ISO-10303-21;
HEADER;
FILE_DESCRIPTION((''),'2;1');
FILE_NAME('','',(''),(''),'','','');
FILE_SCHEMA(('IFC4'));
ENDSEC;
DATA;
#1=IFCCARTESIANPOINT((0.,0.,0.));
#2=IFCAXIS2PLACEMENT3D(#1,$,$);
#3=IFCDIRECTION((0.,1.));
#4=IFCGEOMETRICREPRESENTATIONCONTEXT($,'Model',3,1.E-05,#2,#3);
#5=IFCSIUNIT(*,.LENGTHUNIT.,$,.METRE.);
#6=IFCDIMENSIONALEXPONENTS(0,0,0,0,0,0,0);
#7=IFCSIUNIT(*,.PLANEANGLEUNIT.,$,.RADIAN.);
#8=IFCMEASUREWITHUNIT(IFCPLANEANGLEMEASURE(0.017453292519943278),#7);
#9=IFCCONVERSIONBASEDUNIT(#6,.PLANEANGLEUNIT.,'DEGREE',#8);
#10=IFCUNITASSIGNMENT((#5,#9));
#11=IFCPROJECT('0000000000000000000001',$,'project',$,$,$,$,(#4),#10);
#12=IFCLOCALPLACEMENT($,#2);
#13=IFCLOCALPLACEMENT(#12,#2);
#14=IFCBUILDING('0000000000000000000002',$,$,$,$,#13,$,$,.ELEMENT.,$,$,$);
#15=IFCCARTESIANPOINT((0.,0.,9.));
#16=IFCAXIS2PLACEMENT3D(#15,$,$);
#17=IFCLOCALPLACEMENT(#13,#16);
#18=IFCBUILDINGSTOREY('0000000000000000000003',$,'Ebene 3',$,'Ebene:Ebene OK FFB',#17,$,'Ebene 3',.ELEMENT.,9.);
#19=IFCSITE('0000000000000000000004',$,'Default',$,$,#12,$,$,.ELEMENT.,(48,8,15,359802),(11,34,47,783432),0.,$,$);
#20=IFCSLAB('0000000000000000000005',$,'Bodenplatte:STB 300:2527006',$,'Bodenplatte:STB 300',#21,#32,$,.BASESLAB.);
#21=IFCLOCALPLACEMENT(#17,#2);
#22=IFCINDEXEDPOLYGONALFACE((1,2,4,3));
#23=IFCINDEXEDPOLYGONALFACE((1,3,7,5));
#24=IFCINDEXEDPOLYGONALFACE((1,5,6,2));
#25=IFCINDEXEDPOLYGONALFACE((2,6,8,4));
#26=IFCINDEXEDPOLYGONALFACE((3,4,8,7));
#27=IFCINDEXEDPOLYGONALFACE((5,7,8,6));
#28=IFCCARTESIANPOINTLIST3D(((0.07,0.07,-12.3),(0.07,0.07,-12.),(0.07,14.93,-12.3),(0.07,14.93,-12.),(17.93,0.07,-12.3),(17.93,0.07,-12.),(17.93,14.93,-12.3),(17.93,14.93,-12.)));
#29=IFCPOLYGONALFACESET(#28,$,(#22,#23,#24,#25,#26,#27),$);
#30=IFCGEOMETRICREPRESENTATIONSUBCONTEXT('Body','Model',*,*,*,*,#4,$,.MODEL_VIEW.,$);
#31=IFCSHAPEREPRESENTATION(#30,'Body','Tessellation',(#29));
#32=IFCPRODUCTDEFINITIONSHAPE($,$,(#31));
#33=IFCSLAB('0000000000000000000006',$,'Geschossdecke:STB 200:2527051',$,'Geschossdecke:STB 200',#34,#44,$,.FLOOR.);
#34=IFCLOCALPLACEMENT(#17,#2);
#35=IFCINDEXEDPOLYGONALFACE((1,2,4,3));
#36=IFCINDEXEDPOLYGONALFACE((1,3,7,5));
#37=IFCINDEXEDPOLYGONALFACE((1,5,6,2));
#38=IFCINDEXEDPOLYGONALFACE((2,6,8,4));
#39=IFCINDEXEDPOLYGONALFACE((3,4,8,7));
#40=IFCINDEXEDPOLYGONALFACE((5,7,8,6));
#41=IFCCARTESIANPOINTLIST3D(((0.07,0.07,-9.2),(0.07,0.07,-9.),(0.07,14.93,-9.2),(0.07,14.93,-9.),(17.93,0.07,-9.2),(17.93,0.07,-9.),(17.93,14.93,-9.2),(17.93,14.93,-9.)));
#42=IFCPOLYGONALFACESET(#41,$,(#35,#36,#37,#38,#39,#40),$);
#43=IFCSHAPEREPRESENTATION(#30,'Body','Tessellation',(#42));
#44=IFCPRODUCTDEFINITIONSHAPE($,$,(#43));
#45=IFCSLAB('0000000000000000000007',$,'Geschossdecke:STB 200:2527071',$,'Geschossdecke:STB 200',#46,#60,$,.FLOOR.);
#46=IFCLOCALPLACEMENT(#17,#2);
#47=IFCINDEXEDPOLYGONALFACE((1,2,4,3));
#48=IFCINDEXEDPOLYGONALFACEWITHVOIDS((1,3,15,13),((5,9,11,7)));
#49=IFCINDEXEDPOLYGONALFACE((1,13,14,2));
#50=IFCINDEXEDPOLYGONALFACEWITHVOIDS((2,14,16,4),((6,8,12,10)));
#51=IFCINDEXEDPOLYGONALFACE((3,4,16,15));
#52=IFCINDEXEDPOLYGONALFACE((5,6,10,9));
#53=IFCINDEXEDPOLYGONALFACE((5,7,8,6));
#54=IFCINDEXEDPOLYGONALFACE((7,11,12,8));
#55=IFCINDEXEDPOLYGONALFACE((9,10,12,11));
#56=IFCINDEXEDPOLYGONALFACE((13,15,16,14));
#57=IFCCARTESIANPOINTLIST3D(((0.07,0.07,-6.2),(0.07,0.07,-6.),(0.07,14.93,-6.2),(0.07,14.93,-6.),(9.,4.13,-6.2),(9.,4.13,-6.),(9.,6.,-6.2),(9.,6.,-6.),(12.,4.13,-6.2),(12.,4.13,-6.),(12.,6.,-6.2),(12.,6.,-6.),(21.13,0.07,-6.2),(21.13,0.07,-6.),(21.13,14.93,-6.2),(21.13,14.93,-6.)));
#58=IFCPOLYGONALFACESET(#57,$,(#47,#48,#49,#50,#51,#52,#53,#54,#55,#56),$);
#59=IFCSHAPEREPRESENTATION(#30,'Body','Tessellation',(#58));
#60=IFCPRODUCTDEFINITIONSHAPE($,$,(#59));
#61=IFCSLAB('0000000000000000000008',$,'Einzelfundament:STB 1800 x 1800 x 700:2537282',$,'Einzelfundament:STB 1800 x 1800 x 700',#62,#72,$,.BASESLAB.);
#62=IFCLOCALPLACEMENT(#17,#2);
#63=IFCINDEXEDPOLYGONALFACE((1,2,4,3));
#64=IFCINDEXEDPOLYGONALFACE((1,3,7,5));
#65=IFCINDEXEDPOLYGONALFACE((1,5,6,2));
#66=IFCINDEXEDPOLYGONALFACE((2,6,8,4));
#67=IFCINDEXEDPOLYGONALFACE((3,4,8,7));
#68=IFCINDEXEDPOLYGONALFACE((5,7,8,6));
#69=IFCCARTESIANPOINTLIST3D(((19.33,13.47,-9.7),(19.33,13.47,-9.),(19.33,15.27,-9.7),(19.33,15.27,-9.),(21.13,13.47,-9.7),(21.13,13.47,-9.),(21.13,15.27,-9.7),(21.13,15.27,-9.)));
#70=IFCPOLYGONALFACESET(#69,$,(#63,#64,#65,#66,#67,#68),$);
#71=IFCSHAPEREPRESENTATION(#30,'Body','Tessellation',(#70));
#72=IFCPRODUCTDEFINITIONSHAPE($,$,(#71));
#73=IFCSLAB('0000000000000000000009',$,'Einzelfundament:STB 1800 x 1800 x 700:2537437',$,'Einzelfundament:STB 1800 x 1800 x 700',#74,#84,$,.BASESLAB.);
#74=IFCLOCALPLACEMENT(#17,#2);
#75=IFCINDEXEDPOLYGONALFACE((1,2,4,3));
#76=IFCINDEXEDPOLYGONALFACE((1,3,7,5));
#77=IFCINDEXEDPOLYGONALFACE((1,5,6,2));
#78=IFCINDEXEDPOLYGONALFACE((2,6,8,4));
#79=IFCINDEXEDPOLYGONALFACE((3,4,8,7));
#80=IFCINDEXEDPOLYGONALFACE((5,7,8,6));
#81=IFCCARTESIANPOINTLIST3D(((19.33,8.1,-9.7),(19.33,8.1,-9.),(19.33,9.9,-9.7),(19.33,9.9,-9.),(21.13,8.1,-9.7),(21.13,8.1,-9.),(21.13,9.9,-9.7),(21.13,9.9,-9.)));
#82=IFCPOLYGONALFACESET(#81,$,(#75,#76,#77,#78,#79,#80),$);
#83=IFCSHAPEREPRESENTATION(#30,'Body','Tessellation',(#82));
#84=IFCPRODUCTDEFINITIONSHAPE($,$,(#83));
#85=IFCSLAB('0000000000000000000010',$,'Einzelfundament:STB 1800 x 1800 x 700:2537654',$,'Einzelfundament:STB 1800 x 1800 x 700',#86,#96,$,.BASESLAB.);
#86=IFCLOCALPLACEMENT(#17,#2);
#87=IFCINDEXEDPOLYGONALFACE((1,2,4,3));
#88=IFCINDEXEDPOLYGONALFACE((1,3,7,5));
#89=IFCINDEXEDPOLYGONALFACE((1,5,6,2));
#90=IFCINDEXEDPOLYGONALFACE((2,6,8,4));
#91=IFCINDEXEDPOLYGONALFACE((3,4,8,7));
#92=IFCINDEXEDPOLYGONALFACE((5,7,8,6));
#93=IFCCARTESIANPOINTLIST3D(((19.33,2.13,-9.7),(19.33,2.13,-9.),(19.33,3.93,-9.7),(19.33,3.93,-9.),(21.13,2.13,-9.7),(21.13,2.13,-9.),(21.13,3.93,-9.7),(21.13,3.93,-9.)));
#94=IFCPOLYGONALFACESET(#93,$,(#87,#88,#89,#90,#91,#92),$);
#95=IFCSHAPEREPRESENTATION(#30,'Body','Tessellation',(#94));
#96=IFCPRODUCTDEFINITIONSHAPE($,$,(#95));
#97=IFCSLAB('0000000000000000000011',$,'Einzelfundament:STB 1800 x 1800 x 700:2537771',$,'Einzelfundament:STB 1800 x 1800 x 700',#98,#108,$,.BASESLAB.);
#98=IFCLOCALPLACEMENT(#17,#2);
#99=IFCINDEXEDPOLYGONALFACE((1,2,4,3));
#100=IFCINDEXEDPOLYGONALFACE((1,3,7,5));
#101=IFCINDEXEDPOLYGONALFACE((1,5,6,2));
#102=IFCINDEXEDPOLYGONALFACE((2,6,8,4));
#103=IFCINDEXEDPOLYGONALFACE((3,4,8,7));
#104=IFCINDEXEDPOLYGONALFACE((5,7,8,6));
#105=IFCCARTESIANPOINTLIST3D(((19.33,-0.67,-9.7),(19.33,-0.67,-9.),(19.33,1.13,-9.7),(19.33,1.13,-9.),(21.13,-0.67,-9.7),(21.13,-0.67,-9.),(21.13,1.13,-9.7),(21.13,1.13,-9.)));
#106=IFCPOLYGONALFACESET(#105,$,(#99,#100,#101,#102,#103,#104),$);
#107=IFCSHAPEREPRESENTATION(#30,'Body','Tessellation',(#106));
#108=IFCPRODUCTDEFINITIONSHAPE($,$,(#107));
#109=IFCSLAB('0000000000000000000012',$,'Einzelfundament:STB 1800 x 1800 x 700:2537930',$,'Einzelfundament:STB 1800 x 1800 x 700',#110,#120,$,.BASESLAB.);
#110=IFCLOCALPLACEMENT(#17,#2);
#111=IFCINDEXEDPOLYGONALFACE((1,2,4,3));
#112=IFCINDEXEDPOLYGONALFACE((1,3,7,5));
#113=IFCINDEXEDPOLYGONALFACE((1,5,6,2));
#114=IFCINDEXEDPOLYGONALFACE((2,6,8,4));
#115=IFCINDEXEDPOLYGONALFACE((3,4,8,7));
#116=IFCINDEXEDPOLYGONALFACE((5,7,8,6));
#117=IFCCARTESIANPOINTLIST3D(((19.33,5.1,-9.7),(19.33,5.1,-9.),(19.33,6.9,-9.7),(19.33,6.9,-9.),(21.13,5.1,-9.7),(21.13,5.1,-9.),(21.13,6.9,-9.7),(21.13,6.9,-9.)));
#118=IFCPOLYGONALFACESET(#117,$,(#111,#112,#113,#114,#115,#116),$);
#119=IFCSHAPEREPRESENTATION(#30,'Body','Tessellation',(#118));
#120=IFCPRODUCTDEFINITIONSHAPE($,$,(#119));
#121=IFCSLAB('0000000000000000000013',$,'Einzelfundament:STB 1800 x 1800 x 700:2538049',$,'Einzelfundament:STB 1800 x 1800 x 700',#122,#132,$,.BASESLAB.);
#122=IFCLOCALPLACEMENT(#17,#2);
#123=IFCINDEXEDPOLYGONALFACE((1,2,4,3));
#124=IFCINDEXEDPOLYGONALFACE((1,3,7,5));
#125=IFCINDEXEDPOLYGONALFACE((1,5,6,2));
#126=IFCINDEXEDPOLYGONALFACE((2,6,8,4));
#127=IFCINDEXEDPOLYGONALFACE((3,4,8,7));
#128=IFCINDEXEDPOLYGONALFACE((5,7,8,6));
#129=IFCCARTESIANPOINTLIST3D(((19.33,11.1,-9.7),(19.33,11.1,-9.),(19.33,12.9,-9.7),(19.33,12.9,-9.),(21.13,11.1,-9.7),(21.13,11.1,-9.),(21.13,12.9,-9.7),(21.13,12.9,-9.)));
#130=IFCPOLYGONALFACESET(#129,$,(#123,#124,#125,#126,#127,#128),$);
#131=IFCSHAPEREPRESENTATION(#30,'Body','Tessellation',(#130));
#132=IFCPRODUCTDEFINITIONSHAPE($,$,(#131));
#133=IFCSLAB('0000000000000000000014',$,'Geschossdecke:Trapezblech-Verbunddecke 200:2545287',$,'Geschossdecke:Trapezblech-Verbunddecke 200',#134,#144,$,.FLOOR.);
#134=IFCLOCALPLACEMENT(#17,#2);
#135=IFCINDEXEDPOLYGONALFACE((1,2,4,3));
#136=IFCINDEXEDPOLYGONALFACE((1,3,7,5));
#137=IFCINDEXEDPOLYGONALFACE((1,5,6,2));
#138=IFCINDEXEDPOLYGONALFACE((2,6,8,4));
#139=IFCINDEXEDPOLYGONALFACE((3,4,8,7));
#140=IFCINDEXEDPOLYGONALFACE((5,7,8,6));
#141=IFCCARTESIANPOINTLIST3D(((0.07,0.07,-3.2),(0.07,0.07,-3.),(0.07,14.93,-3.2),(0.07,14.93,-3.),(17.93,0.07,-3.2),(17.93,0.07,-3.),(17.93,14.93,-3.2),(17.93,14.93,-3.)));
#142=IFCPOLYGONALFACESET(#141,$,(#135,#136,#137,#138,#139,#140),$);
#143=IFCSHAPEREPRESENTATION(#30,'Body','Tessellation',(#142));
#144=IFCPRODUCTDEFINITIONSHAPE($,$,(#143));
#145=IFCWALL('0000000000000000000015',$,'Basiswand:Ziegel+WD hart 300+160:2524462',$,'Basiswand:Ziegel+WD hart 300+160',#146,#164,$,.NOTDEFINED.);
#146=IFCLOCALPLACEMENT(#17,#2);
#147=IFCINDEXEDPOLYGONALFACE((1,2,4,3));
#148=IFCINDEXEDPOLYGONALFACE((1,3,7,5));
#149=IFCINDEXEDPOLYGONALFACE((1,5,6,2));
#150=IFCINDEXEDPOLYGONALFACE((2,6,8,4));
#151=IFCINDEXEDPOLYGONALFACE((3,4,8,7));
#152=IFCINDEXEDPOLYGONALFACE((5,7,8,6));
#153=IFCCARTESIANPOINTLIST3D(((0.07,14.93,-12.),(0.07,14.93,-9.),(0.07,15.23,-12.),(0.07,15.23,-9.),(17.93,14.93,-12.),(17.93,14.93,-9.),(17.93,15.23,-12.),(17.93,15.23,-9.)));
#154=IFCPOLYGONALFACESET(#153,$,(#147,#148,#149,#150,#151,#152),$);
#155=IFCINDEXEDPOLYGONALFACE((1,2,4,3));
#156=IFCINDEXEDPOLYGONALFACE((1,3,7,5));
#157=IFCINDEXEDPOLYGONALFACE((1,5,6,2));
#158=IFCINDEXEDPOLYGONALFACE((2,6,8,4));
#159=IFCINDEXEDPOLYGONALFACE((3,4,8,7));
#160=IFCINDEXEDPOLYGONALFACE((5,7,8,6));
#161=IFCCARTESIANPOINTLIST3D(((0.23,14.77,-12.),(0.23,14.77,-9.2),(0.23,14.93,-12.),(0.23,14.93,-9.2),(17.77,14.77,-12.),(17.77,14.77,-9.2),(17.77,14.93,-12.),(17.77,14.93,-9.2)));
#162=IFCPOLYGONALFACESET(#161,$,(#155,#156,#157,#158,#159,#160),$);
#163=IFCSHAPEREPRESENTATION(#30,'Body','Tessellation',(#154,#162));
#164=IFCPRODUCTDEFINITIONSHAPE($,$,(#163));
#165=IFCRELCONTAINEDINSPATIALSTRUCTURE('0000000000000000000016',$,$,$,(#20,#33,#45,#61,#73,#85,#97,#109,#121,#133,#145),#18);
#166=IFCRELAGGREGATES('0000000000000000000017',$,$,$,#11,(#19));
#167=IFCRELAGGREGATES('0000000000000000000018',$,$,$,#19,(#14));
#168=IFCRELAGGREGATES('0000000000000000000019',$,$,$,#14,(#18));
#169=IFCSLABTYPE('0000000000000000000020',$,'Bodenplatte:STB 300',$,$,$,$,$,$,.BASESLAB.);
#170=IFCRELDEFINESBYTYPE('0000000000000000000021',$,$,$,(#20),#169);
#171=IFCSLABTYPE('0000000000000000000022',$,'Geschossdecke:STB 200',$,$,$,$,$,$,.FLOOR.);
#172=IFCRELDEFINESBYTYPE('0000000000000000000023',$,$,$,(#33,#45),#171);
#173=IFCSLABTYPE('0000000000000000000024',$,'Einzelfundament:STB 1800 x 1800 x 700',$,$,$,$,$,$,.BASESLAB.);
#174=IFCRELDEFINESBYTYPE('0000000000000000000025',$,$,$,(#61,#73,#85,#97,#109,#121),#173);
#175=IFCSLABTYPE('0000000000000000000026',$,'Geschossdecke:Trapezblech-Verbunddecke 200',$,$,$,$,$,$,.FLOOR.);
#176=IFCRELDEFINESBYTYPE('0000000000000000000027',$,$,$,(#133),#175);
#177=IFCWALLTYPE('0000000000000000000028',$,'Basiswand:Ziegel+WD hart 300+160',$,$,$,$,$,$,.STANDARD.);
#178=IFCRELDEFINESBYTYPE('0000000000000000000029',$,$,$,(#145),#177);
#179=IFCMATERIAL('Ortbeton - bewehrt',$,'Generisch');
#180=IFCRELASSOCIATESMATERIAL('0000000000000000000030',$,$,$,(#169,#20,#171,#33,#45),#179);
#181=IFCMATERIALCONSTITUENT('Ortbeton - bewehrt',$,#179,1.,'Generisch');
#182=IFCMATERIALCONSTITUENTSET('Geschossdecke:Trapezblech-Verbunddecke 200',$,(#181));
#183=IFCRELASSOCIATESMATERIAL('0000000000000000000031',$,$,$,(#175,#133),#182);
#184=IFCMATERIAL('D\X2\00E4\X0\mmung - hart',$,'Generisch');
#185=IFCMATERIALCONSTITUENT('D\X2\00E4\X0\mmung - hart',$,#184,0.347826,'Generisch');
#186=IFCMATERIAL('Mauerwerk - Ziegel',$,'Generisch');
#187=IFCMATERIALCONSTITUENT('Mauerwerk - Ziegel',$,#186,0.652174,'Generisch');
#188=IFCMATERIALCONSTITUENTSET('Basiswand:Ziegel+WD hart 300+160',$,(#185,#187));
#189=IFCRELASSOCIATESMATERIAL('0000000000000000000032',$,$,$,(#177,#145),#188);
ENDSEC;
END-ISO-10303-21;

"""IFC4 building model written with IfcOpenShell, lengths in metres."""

from ifc_helpers import new_model, entity, si_unit, converted_unit, direction, frame, origin, place, context, subcontext, project, spatial, indexed_curve, outline, extrude, material, constituent, constituent_set, type_object, element, save


model = new_model("IFC4")

# Units and contexts
model_context = context("Model", 3, precision=1e-05, world=origin(), true_north=direction((0.0, 1.0)))
body_context = subcontext(model_context, "Body", "Model", "MODEL_VIEW")
ifc_project = project(units=[si_unit("LENGTHUNIT", "METRE"), converted_unit("PLANEANGLEUNIT", "DEGREE", entity("IfcPlaneAngleMeasure", 0.017453292519943278), si_unit("PLANEANGLEUNIT", "RADIAN"), dimensions=[0, 0, 0, 0, 0, 0, 0])], contexts=[model_context])

# Site, building, storey
site_placement = place(None, origin())
site = spatial("IfcSite", under=ifc_project, at=site_placement, Name="Default", CompositionType="ELEMENT", RefLatitude=(48, 8, 15, 359802), RefLongitude=(11, 34, 47, 783432), RefElevation=0.0)
building_placement = place(site_placement, origin())
building = spatial("IfcBuilding", under=site, at=building_placement, CompositionType="ELEMENT")
storey_placement = place(building_placement, frame((0.0, 0.0, 9.0)))
storey = spatial("IfcBuildingStorey", under=building, at=storey_placement, Name="Ebene 3", ObjectType="Ebene:Ebene OK FFB", LongName="Ebene 3", CompositionType="ELEMENT", Elevation=9.0)

# Slabs
ifc_material_1 = material(Name="Ortbeton - bewehrt", Category="Generisch")
slab_type_1 = type_object("IfcSlabType", Name="Bodenplatte:STB 300", PredefinedType="BASESLAB", material=ifc_material_1)
slab_1_placement = place(storey_placement, origin())
element("IfcSlab", 1, at=slab_1_placement, inside=storey, type_object=slab_type_1, material=ifc_material_1, Name="Bodenplatte:STB 300:2527006", ObjectType="Bodenplatte:STB 300", PredefinedType="BASESLAB", context=body_context, shape_type="SweptSolid", body=[
    extrude(outline(indexed_curve([(-7.43, -8.93), (7.43, -8.93), (7.43, 8.93), (-7.43, 8.93), (-7.43, -8.93)], self_intersect=False)), frame((9.0, 7.5, -12.0), z_axis=(0.0, 0.0, -1.0), x_axis=(0.0, 1.0, 0.0)), (0.0, 0.0, 1.0), 0.3),
])
slab_type_2 = type_object("IfcSlabType", Name="Geschossdecke:STB 200", PredefinedType="FLOOR", material=ifc_material_1)
slab_2_placement = place(storey_placement, origin())
element("IfcSlab", 2, at=slab_2_placement, inside=storey, type_object=slab_type_2, material=ifc_material_1, Name="Geschossdecke:STB 200:2527051", ObjectType="Geschossdecke:STB 200", PredefinedType="FLOOR", context=body_context, shape_type="SweptSolid", body=[
    extrude(outline(indexed_curve([(-7.43, -8.93), (7.43, -8.93), (7.43, 8.93), (-7.43, 8.93), (-7.43, -8.93)], self_intersect=False)), frame((9.0, 7.5, -9.0), z_axis=(0.0, 0.0, -1.0), x_axis=(0.0, 1.0, 0.0)), (0.0, 0.0, 1.0), 0.2),
])

# Slab, opening
slab_3_placement = place(storey_placement, origin())
slab_3 = element("IfcSlab", 3, at=slab_3_placement, inside=storey, type_object=slab_type_2, material=ifc_material_1, Name="Geschossdecke:STB 200:2527071", ObjectType="Geschossdecke:STB 200", PredefinedType="FLOOR", context=body_context, shape_type="SweptSolid", body=[
    extrude(outline(indexed_curve([(-10.53, -7.43), (10.53, -7.43), (10.53, 7.43), (-10.53, 7.43), (-10.53, -7.43)], self_intersect=False), holes=[indexed_curve([(1.4, -1.5), (1.4, -3.37), (-1.6, -3.37), (-1.6, -1.5), (1.4, -1.5)], self_intersect=False)]), frame((10.6, 7.5, -6.2)), (0.0, 0.0, 1.0), 0.2),
])
opening_1_placement = place(slab_3_placement, origin())
element("IfcOpeningElement", 4, at=opening_1_placement, cuts=slab_3, PredefinedType="OPENING", context=body_context, shape_type="SweptSolid", body=[
    extrude(outline(indexed_curve([(12.0, 6.0), (9.0, 6.0), (9.0, 4.13), (12.0, 4.13), (12.0, 6.0)], self_intersect=False)), frame((0.0, 0.0, -9.0)), (0.0, 0.0, -1.0), 14.86),
])

# Slabs
slab_type_3 = type_object("IfcSlabType", Name="Einzelfundament:STB 1800 x 1800 x 700", PredefinedType="BASESLAB")
slab_4_placement = place(storey_placement, origin())
element("IfcSlab", 5, at=slab_4_placement, inside=storey, type_object=slab_type_3, Name="Einzelfundament:STB 1800 x 1800 x 700:2537282", ObjectType="Einzelfundament:STB 1800 x 1800 x 700", PredefinedType="BASESLAB", context=body_context, shape_type="SweptSolid", body=[
    extrude(outline(indexed_curve([(-0.9, -0.9), (0.9, -0.9), (0.9, 0.9), (-0.9, 0.9), (-0.9, -0.9)], self_intersect=False)), frame((20.23, 14.37, -9.7), z_axis=(0.0, 0.0, 1.0), x_axis=(-1.0, 0.0, 0.0)), (0.0, 0.0, 1.0), 0.7),
])
slab_5_placement = place(storey_placement, origin())
element("IfcSlab", 6, at=slab_5_placement, inside=storey, type_object=slab_type_3, Name="Einzelfundament:STB 1800 x 1800 x 700:2537437", ObjectType="Einzelfundament:STB 1800 x 1800 x 700", PredefinedType="BASESLAB", context=body_context, shape_type="SweptSolid", body=[
    extrude(outline(indexed_curve([(-0.9, -0.9), (0.9, -0.9), (0.9, 0.9), (-0.9, 0.9), (-0.9, -0.9)], self_intersect=False)), frame((20.23, 9.0, -9.7), z_axis=(0.0, 0.0, 1.0), x_axis=(-1.0, 0.0, 0.0)), (0.0, 0.0, 1.0), 0.7),
])
slab_6_placement = place(storey_placement, origin())
element("IfcSlab", 7, at=slab_6_placement, inside=storey, type_object=slab_type_3, Name="Einzelfundament:STB 1800 x 1800 x 700:2537654", ObjectType="Einzelfundament:STB 1800 x 1800 x 700", PredefinedType="BASESLAB", context=body_context, shape_type="SweptSolid", body=[
    extrude(outline(indexed_curve([(-0.9, -0.9), (0.9, -0.9), (0.9, 0.9), (-0.9, 0.9), (-0.9, -0.9)], self_intersect=False)), frame((20.23, 3.03, -9.7), z_axis=(0.0, 0.0, 1.0), x_axis=(-1.0, 0.0, 0.0)), (0.0, 0.0, 1.0), 0.7),
])
slab_7_placement = place(storey_placement, origin())
element("IfcSlab", 8, at=slab_7_placement, inside=storey, type_object=slab_type_3, Name="Einzelfundament:STB 1800 x 1800 x 700:2537771", ObjectType="Einzelfundament:STB 1800 x 1800 x 700", PredefinedType="BASESLAB", context=body_context, shape_type="SweptSolid", body=[
    extrude(outline(indexed_curve([(-0.9, -0.9), (0.9, -0.9), (0.9, 0.9), (-0.9, 0.9), (-0.9, -0.9)], self_intersect=False)), frame((20.23, 0.23, -9.7), z_axis=(0.0, 0.0, 1.0), x_axis=(-1.0, 0.0, 0.0)), (0.0, 0.0, 1.0), 0.7),
])
slab_8_placement = place(storey_placement, origin())
element("IfcSlab", 9, at=slab_8_placement, inside=storey, type_object=slab_type_3, Name="Einzelfundament:STB 1800 x 1800 x 700:2537930", ObjectType="Einzelfundament:STB 1800 x 1800 x 700", PredefinedType="BASESLAB", context=body_context, shape_type="SweptSolid", body=[
    extrude(outline(indexed_curve([(-0.9, -0.9), (0.9, -0.9), (0.9, 0.9), (-0.9, 0.9), (-0.9, -0.9)], self_intersect=False)), frame((20.23, 6.0, -9.7), z_axis=(0.0, 0.0, 1.0), x_axis=(-1.0, 0.0, 0.0)), (0.0, 0.0, 1.0), 0.7),
])
slab_9_placement = place(storey_placement, origin())
element("IfcSlab", 10, at=slab_9_placement, inside=storey, type_object=slab_type_3, Name="Einzelfundament:STB 1800 x 1800 x 700:2538049", ObjectType="Einzelfundament:STB 1800 x 1800 x 700", PredefinedType="BASESLAB", context=body_context, shape_type="SweptSolid", body=[
    extrude(outline(indexed_curve([(-0.9, -0.9), (0.9, -0.9), (0.9, 0.9), (-0.9, 0.9), (-0.9, -0.9)], self_intersect=False)), frame((20.23, 12.0, -9.7), z_axis=(0.0, 0.0, 1.0), x_axis=(-1.0, 0.0, 0.0)), (0.0, 0.0, 1.0), 0.7),
])
ifc_constituent_1 = constituent(ifc_material_1, Name="Ortbeton - bewehrt", Category="Generisch", fraction=1.0)
ifc_constituent_set_1 = constituent_set(constituents=[ifc_constituent_1], Name="Geschossdecke:Trapezblech-Verbunddecke 200")
slab_type_4 = type_object("IfcSlabType", Name="Geschossdecke:Trapezblech-Verbunddecke 200", PredefinedType="FLOOR", material=ifc_constituent_set_1)
slab_10_placement = place(storey_placement, origin())
element("IfcSlab", 11, at=slab_10_placement, inside=storey, type_object=slab_type_4, material=ifc_constituent_set_1, Name="Geschossdecke:Trapezblech-Verbunddecke 200:2545287", ObjectType="Geschossdecke:Trapezblech-Verbunddecke 200", PredefinedType="FLOOR", context=body_context, shape_type="SweptSolid", body=[
    extrude(outline(indexed_curve([(-7.43, -8.93), (7.43, -8.93), (7.43, 8.93), (-7.43, 8.93), (-7.43, -8.93)], self_intersect=False)), frame((9.0, 7.5, -3.0), z_axis=(0.0, 0.0, -1.0), x_axis=(0.0, 1.0, 0.0)), (0.0, 0.0, 1.0), 0.2),
])

# Wall
ifc_material_2 = material(Name="Dämmung - hart", Category="Generisch")
ifc_constituent_2 = constituent(ifc_material_2, Name="Dämmung - hart", Category="Generisch", fraction=0.347826)
ifc_material_3 = material(Name="Mauerwerk - Ziegel", Category="Generisch")
ifc_constituent_3 = constituent(ifc_material_3, Name="Mauerwerk - Ziegel", Category="Generisch", fraction=0.652174)
ifc_constituent_set_2 = constituent_set(constituents=[ifc_constituent_2, ifc_constituent_3], Name="Basiswand:Ziegel+WD hart 300+160")
wall_type = type_object("IfcWallType", Name="Basiswand:Ziegel+WD hart 300+160", PredefinedType="STANDARD", material=ifc_constituent_set_2)
wall_1_placement = place(storey_placement, frame((17.77, 15.0, -12.0), z_axis=(0.0, 0.0, 1.0), x_axis=(-1.0, 0.0, 0.0)))
element("IfcWall", 12, at=wall_1_placement, inside=storey, type_object=wall_type, material=ifc_constituent_set_2, Name="Basiswand:Ziegel+WD hart 300+160:2524462", ObjectType="Basiswand:Ziegel+WD hart 300+160", PredefinedType="NOTDEFINED", context=body_context, shape_type="SweptSolid", body=[
    extrude(outline(indexed_curve([(-0.15, -8.93), (0.15, -8.93), (0.15, 8.93), (-0.15, 8.93), (-0.15, -8.93)], self_intersect=False)), frame((8.77, -0.08, 0.0), z_axis=(0.0, 0.0, 1.0), x_axis=(0.0, 1.0, 0.0)), (0.0, 0.0, 1.0), 3.0),
    extrude(outline(indexed_curve([(-0.08, -8.77), (0.08, -8.77), (0.08, 8.77), (-0.08, 8.77), (-0.08, -8.77)], self_intersect=False)), frame((8.77, 0.15, 0.0), z_axis=(0.0, 0.0, 1.0), x_axis=(0.0, -1.0, 0.0)), (0.0, 0.0, 1.0), 2.8),
])

save(model, "model.ifc")
